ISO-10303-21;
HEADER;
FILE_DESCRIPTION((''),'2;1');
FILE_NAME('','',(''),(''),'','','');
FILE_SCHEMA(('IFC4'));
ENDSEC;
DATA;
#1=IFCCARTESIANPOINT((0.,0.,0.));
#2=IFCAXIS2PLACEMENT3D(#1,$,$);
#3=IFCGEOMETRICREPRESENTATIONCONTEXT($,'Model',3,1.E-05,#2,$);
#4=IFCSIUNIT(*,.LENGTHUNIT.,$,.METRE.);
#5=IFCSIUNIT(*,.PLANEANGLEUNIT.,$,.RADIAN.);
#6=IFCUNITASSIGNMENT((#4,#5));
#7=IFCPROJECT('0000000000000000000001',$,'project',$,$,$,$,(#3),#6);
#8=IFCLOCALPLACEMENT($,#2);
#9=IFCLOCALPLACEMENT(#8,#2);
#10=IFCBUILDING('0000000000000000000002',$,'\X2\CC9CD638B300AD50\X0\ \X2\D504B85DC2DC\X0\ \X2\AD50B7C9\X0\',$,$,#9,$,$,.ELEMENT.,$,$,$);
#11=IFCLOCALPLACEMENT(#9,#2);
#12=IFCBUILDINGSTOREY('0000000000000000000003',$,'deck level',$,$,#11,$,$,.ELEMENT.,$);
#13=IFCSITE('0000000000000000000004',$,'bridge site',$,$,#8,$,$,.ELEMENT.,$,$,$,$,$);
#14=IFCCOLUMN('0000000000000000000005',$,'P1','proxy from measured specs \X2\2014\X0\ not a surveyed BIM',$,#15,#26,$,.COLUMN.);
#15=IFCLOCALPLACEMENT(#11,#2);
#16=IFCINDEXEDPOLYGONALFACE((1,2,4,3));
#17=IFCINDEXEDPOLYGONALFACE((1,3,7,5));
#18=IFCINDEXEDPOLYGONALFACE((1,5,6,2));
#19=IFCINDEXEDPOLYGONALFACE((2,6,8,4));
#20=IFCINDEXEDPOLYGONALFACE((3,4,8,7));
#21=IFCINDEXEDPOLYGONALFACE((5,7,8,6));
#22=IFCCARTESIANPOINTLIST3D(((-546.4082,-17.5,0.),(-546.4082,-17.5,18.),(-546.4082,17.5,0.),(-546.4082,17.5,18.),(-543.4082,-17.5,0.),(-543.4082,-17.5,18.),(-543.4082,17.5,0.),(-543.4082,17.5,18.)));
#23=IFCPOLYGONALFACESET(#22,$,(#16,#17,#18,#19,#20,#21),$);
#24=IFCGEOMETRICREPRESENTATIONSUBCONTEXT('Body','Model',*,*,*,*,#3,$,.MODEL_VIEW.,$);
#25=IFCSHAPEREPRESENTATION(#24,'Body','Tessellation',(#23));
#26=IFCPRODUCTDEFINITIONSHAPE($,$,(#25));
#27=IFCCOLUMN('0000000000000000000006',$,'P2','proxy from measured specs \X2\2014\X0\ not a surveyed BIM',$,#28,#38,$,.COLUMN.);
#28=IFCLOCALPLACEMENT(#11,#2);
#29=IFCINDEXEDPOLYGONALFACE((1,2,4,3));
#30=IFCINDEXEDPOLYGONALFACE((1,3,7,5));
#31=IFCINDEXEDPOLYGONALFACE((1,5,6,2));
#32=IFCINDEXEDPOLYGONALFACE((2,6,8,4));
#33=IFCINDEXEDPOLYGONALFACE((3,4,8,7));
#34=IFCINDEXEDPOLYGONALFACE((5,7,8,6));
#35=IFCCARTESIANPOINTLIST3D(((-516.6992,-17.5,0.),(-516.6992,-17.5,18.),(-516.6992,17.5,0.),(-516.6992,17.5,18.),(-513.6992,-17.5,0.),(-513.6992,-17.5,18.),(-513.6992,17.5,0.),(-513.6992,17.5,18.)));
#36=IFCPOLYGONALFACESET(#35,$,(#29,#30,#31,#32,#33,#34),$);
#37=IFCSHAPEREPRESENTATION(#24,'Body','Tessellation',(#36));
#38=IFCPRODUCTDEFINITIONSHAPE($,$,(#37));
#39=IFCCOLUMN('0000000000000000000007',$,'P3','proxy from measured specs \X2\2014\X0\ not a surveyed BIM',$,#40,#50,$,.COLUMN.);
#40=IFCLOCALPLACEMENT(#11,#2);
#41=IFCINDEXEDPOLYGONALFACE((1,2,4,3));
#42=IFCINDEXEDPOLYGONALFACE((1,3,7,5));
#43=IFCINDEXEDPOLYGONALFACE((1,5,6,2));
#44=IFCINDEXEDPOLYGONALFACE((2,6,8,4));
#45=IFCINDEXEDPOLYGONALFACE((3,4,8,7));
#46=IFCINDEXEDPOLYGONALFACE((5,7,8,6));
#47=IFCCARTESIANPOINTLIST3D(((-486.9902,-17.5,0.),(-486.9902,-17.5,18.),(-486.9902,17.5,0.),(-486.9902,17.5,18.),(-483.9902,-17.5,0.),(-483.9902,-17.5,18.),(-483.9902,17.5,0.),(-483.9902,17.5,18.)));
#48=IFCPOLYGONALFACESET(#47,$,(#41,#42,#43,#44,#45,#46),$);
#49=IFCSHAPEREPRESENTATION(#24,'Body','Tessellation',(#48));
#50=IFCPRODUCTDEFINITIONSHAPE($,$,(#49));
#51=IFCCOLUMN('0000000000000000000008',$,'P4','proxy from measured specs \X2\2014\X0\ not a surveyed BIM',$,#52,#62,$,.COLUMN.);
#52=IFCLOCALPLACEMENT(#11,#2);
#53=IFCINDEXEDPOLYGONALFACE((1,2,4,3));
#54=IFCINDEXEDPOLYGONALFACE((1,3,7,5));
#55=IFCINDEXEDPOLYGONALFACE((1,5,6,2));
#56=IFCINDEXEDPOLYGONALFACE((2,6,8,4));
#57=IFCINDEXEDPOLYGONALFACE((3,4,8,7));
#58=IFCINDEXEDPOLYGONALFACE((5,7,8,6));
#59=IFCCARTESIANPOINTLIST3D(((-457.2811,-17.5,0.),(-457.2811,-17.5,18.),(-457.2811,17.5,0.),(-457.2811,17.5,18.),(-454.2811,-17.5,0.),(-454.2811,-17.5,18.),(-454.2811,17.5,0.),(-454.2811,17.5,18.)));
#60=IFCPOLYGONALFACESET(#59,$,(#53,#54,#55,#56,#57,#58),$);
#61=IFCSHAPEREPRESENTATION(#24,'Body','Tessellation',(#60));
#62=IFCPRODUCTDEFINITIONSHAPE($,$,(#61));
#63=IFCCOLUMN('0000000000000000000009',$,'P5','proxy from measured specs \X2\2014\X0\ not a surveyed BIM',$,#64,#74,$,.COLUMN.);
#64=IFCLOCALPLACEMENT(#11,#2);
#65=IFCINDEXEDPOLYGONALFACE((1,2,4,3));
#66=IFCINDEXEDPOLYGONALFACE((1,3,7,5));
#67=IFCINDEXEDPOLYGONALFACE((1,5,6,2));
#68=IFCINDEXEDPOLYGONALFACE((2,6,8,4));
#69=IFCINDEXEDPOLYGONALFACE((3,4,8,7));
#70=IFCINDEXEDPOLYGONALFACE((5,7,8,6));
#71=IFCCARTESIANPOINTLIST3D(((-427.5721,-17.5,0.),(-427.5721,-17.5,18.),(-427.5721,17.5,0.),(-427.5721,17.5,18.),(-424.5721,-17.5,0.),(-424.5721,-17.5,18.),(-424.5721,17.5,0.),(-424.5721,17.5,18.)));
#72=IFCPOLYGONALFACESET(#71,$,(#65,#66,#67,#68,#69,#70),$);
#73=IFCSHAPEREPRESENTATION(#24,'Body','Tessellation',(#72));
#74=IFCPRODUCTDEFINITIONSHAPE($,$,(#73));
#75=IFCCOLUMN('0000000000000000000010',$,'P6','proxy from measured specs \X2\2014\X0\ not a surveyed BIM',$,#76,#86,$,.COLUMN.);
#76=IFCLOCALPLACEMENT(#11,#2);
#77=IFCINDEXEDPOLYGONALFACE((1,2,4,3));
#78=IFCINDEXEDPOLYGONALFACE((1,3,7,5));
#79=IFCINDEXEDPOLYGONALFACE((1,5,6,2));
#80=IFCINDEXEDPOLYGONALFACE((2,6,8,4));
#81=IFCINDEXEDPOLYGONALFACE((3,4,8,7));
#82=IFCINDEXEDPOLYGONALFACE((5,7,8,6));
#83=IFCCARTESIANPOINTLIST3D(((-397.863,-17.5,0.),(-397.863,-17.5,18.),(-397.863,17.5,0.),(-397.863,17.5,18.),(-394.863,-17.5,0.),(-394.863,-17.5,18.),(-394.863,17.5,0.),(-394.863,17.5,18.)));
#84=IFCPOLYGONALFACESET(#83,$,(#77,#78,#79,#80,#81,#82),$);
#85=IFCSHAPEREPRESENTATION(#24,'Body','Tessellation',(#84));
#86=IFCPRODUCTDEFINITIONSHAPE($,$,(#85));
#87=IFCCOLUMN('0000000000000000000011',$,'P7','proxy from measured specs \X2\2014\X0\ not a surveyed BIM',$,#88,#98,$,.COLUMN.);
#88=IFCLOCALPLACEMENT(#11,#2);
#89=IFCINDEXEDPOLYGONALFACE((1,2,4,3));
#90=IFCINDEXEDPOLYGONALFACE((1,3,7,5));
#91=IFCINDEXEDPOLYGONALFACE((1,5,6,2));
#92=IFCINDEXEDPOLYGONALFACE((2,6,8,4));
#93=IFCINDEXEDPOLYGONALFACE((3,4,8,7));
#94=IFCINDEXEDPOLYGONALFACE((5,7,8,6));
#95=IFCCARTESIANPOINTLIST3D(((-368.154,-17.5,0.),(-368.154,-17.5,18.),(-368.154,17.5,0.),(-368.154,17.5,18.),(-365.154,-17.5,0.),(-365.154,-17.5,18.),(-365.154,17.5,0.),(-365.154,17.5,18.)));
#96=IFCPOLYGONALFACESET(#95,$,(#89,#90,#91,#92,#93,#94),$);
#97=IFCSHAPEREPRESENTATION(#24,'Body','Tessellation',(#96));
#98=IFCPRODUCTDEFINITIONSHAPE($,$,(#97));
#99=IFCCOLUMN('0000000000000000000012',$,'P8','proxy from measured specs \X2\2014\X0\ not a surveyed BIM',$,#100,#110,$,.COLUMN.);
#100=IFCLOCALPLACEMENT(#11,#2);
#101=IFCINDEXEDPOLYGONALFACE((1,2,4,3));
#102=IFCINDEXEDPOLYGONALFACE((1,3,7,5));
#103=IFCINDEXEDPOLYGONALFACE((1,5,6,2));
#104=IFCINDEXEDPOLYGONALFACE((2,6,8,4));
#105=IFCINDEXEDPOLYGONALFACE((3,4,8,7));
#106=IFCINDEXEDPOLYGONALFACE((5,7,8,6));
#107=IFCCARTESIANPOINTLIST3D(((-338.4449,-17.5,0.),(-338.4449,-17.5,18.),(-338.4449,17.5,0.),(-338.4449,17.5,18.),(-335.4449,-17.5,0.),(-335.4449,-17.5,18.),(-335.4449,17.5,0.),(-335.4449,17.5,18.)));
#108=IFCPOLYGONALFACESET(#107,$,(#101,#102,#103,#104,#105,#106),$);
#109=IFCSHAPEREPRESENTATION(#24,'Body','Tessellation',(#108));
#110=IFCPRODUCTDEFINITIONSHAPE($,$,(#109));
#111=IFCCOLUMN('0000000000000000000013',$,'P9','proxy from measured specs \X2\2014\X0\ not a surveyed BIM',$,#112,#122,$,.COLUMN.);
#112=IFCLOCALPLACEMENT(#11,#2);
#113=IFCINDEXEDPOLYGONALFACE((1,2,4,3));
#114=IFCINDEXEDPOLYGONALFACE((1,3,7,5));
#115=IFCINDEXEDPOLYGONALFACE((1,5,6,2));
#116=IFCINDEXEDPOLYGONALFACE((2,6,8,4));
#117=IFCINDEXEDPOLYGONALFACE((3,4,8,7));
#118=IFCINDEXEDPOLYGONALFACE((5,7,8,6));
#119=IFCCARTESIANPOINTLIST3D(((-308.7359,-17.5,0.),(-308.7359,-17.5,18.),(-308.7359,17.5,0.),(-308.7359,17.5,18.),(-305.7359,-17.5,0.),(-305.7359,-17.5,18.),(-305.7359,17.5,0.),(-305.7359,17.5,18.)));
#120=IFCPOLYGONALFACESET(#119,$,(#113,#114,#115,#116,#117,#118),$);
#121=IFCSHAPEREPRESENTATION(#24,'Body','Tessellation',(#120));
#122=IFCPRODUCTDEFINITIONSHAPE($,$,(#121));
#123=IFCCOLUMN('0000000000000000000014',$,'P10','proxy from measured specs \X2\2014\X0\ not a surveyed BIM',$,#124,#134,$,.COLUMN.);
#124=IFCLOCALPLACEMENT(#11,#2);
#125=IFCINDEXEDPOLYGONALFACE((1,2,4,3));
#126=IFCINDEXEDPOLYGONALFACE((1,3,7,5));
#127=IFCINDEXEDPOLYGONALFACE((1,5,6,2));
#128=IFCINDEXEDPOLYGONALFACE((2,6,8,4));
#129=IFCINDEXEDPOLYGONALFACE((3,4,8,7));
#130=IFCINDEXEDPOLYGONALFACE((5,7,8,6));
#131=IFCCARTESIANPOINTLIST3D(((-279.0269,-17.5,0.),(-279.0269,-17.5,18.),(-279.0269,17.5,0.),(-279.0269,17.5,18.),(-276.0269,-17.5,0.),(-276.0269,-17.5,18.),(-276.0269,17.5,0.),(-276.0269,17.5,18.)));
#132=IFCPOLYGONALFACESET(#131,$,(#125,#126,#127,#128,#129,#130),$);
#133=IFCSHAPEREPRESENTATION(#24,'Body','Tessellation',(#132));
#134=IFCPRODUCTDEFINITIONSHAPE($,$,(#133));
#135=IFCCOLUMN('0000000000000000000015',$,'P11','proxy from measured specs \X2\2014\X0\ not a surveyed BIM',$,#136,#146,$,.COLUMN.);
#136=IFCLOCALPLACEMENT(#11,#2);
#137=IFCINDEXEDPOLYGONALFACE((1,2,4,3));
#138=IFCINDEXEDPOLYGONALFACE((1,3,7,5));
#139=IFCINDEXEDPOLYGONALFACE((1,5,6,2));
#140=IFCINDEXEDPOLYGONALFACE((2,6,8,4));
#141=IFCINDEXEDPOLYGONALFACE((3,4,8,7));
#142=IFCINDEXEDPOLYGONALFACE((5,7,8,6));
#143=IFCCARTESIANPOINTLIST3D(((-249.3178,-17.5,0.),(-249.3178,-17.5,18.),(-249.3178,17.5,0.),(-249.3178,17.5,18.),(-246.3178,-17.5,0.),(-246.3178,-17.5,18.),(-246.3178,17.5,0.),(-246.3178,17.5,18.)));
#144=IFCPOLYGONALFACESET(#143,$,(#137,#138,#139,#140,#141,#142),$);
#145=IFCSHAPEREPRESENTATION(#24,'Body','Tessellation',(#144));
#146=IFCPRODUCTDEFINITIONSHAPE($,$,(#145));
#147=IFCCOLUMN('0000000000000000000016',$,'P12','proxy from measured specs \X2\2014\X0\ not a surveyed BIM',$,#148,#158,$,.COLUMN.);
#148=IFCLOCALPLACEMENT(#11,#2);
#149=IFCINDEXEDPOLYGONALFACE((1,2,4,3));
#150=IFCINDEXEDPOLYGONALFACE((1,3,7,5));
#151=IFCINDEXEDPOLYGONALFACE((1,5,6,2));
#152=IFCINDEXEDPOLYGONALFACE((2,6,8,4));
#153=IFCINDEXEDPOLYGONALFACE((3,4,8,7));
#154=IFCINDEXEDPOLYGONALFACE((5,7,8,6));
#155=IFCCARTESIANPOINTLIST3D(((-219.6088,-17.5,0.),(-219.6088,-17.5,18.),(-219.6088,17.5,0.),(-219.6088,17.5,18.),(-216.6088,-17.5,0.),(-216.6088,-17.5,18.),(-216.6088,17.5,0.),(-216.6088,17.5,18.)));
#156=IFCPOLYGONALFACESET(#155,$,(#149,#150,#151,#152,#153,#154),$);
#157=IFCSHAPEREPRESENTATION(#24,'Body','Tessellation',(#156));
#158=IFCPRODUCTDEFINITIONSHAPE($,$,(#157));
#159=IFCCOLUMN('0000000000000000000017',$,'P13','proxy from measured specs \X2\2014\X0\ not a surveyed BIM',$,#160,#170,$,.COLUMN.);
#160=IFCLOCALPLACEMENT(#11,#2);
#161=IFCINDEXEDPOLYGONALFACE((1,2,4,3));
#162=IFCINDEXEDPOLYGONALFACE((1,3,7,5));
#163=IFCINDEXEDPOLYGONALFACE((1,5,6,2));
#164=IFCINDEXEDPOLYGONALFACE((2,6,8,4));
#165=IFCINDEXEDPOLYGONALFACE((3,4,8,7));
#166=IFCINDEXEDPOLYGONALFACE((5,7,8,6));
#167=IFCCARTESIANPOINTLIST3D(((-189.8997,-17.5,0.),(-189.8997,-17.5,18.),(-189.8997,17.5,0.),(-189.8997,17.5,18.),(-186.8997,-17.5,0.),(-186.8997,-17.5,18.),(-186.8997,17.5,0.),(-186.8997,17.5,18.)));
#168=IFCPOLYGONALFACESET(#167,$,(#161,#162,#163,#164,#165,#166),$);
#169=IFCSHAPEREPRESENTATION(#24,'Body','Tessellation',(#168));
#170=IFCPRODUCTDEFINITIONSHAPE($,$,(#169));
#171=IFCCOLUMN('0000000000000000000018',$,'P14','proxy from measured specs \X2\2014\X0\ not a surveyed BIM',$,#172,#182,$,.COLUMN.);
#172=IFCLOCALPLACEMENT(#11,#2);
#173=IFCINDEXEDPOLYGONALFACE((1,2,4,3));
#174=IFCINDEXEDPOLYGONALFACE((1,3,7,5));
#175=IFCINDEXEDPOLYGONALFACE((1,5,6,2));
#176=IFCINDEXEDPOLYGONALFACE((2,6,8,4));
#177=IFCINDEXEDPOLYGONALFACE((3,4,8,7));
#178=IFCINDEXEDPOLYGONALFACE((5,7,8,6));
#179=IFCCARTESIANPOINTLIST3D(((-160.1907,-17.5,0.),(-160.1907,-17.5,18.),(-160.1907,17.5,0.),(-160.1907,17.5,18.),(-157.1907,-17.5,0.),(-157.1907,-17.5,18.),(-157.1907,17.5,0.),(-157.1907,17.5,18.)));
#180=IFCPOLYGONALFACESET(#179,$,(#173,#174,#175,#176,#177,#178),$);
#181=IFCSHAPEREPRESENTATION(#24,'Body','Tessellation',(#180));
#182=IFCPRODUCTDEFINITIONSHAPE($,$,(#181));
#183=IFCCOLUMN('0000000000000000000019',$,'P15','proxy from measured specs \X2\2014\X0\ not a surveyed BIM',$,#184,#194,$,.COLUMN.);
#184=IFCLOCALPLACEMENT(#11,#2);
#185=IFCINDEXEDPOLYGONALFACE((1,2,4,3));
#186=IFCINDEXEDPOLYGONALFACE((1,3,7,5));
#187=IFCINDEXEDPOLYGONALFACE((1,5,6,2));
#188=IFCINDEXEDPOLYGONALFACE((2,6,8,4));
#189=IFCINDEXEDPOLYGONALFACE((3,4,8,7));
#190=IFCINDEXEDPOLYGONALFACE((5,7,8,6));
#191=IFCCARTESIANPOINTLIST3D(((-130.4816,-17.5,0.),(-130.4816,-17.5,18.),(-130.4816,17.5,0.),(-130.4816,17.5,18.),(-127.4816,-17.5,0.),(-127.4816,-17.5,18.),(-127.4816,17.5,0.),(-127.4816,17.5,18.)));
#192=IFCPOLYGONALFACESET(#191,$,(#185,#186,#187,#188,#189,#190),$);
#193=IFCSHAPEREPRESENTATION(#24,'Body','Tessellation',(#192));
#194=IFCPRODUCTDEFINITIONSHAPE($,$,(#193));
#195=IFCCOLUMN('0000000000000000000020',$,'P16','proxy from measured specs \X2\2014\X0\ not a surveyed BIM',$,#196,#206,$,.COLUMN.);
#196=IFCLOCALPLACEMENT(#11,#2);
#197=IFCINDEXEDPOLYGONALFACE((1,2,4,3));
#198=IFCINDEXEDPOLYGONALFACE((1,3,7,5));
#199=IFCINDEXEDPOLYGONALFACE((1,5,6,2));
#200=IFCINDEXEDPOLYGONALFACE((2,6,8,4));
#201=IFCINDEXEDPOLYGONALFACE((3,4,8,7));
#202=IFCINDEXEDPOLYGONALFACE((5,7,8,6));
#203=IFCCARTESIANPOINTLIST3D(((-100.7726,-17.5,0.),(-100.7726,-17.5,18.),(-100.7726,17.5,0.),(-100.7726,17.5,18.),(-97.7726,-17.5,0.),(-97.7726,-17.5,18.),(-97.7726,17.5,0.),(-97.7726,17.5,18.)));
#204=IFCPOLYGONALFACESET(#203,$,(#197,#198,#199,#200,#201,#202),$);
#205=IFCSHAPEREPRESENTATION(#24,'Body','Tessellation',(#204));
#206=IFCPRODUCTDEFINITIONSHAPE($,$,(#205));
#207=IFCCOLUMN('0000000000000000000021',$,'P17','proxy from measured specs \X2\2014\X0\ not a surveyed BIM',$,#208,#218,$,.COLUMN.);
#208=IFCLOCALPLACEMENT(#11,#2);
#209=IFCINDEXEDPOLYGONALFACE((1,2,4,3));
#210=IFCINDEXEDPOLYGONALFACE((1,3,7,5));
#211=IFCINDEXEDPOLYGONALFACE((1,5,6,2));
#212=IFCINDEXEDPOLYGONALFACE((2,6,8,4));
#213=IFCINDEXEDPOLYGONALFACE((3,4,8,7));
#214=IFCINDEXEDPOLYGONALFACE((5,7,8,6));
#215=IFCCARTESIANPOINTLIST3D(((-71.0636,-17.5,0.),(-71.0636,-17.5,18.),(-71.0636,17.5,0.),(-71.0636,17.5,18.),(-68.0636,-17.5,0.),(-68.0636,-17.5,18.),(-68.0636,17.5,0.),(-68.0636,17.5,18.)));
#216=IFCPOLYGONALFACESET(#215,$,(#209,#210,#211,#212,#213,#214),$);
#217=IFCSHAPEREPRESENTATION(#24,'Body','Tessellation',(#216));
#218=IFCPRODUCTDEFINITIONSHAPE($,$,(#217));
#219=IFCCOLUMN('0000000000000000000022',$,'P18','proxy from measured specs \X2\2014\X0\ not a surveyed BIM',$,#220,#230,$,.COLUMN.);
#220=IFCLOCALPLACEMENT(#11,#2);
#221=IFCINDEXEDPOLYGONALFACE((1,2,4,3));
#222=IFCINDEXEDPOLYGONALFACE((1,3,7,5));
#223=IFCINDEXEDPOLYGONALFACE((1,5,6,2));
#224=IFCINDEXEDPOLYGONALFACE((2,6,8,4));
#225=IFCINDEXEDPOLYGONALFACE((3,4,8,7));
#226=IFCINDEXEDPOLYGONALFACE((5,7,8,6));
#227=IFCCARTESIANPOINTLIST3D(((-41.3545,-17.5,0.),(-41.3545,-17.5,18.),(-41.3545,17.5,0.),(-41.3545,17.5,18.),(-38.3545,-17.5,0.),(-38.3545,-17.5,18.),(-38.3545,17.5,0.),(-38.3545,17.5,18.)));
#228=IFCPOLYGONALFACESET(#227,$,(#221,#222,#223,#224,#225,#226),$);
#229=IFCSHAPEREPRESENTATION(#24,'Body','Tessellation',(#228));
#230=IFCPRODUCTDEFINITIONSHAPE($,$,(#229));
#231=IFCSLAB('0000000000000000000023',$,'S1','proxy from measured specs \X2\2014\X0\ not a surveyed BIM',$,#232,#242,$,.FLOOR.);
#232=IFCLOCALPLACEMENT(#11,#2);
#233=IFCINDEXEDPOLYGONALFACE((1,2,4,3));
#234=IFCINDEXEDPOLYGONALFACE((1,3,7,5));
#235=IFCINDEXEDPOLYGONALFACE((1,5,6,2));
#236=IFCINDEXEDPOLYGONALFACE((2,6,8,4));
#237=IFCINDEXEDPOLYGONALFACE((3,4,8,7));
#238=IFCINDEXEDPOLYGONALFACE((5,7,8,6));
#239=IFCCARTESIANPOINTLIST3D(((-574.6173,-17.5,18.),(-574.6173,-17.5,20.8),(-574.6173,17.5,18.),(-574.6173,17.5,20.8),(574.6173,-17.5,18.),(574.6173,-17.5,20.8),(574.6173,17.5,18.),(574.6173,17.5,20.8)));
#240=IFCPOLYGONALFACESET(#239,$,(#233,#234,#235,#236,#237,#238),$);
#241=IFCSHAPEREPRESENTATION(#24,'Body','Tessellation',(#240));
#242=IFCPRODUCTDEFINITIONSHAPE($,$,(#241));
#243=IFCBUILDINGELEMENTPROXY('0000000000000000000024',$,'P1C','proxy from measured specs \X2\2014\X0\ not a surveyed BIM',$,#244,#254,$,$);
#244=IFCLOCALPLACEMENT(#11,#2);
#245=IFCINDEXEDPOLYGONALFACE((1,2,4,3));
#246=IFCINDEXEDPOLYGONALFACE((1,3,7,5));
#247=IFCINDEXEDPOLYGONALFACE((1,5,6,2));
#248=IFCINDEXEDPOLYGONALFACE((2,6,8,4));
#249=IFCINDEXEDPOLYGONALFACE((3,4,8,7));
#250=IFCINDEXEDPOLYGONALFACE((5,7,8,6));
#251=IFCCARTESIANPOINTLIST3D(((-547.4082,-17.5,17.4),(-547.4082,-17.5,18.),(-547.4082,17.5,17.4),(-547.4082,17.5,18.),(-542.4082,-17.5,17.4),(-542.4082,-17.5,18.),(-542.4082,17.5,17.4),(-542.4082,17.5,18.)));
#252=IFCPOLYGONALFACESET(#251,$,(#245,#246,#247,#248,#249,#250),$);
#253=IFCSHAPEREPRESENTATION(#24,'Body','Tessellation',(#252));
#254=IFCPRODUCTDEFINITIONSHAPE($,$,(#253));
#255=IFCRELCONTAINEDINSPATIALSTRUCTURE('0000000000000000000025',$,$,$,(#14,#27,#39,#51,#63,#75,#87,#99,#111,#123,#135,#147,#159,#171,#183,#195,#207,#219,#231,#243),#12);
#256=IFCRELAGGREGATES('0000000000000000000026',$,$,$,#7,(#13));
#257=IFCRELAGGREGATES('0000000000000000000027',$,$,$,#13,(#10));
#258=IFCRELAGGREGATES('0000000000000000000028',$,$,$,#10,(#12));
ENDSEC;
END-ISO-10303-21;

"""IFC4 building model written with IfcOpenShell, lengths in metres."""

from ifc_helpers import new_model, si_unit, frame, origin, origin_2d, place, context, subcontext, project, spatial, rectangle, extrude, element, save


model = new_model("IFC4")

# Units and contexts
model_context = context("Model", 3, precision=1e-05, world=origin())
body_context = subcontext(model_context, "Body", "Model", "MODEL_VIEW")
ifc_project = project(units=[si_unit("LENGTHUNIT", "METRE"), si_unit("PLANEANGLEUNIT", "RADIAN")], contexts=[model_context])

# Site, building, storey
site_placement = place(None, origin())
site = spatial("IfcSite", under=ifc_project, at=site_placement, Name="bridge site", CompositionType="ELEMENT")
building_placement = place(site_placement, origin())
building = spatial("IfcBuilding", under=site, at=building_placement, Name="천호대교 프록시 교량", CompositionType="ELEMENT")
storey_placement = place(building_placement, origin())
storey = spatial("IfcBuildingStorey", under=building, at=storey_placement, Name="deck level", CompositionType="ELEMENT")

# Columns
for number, where, name in (
    (1, (-544.9082, 0.0, 0.0), "P1"),
    (2, (-515.1992, 0.0, 0.0), "P2"),
    (3, (-485.4902, 0.0, 0.0), "P3"),
    (4, (-455.7811, 0.0, 0.0), "P4"),
    (5, (-426.0721, 0.0, 0.0), "P5"),
    (6, (-396.363, 0.0, 0.0), "P6"),
    (7, (-366.654, 0.0, 0.0), "P7"),
    (8, (-336.9449, 0.0, 0.0), "P8"),
    (9, (-307.2359, 0.0, 0.0), "P9"),
    (10, (-277.5269, 0.0, 0.0), "P10"),
    (11, (-247.8178, 0.0, 0.0), "P11"),
    (12, (-218.1088, 0.0, 0.0), "P12"),
    (13, (-188.3997, 0.0, 0.0), "P13"),
    (14, (-158.6907, 0.0, 0.0), "P14"),
    (15, (-128.9816, 0.0, 0.0), "P15"),
    (16, (-99.2726, 0.0, 0.0), "P16"),
    (17, (-69.5636, 0.0, 0.0), "P17"),
    (18, (-39.8545, 0.0, 0.0), "P18"),
):
    element("IfcColumn", number, at=place(storey_placement, frame(where)), inside=storey, Name=name, Description="proxy from measured specs — not a surveyed BIM", PredefinedType="COLUMN", context=body_context, shape_type="SweptSolid", body=[
        extrude(rectangle(XDim=3.0, YDim=35.0, at=origin_2d()), origin(), (0.0, 0.0, 1.0), 18.0),
    ])

# Slab
slab_placement = place(storey_placement, frame((0.0, 0.0, 18.0)))
element("IfcSlab", 19, at=slab_placement, inside=storey, Name="S1", Description="proxy from measured specs — not a surveyed BIM", PredefinedType="FLOOR", context=body_context, shape_type="SweptSolid", body=[
    extrude(rectangle(XDim=1149.2346, YDim=35.0, at=origin_2d()), origin(), (0.0, 0.0, 1.0), 2.8),
])

# Building element proxy
for number, where, name in (
    (20, (-544.9082, 0.0, 17.4), "P1C"),
):
    element("IfcBuildingElementProxy", number, at=place(storey_placement, frame(where)), inside=storey, Name=name, Description="proxy from measured specs — not a surveyed BIM", context=body_context, shape_type="SweptSolid", body=[
        extrude(rectangle(XDim=5.0, YDim=35.0, at=origin_2d()), origin(), (0.0, 0.0, 1.0), 0.6),
    ])

save(model, "model.ifc")
